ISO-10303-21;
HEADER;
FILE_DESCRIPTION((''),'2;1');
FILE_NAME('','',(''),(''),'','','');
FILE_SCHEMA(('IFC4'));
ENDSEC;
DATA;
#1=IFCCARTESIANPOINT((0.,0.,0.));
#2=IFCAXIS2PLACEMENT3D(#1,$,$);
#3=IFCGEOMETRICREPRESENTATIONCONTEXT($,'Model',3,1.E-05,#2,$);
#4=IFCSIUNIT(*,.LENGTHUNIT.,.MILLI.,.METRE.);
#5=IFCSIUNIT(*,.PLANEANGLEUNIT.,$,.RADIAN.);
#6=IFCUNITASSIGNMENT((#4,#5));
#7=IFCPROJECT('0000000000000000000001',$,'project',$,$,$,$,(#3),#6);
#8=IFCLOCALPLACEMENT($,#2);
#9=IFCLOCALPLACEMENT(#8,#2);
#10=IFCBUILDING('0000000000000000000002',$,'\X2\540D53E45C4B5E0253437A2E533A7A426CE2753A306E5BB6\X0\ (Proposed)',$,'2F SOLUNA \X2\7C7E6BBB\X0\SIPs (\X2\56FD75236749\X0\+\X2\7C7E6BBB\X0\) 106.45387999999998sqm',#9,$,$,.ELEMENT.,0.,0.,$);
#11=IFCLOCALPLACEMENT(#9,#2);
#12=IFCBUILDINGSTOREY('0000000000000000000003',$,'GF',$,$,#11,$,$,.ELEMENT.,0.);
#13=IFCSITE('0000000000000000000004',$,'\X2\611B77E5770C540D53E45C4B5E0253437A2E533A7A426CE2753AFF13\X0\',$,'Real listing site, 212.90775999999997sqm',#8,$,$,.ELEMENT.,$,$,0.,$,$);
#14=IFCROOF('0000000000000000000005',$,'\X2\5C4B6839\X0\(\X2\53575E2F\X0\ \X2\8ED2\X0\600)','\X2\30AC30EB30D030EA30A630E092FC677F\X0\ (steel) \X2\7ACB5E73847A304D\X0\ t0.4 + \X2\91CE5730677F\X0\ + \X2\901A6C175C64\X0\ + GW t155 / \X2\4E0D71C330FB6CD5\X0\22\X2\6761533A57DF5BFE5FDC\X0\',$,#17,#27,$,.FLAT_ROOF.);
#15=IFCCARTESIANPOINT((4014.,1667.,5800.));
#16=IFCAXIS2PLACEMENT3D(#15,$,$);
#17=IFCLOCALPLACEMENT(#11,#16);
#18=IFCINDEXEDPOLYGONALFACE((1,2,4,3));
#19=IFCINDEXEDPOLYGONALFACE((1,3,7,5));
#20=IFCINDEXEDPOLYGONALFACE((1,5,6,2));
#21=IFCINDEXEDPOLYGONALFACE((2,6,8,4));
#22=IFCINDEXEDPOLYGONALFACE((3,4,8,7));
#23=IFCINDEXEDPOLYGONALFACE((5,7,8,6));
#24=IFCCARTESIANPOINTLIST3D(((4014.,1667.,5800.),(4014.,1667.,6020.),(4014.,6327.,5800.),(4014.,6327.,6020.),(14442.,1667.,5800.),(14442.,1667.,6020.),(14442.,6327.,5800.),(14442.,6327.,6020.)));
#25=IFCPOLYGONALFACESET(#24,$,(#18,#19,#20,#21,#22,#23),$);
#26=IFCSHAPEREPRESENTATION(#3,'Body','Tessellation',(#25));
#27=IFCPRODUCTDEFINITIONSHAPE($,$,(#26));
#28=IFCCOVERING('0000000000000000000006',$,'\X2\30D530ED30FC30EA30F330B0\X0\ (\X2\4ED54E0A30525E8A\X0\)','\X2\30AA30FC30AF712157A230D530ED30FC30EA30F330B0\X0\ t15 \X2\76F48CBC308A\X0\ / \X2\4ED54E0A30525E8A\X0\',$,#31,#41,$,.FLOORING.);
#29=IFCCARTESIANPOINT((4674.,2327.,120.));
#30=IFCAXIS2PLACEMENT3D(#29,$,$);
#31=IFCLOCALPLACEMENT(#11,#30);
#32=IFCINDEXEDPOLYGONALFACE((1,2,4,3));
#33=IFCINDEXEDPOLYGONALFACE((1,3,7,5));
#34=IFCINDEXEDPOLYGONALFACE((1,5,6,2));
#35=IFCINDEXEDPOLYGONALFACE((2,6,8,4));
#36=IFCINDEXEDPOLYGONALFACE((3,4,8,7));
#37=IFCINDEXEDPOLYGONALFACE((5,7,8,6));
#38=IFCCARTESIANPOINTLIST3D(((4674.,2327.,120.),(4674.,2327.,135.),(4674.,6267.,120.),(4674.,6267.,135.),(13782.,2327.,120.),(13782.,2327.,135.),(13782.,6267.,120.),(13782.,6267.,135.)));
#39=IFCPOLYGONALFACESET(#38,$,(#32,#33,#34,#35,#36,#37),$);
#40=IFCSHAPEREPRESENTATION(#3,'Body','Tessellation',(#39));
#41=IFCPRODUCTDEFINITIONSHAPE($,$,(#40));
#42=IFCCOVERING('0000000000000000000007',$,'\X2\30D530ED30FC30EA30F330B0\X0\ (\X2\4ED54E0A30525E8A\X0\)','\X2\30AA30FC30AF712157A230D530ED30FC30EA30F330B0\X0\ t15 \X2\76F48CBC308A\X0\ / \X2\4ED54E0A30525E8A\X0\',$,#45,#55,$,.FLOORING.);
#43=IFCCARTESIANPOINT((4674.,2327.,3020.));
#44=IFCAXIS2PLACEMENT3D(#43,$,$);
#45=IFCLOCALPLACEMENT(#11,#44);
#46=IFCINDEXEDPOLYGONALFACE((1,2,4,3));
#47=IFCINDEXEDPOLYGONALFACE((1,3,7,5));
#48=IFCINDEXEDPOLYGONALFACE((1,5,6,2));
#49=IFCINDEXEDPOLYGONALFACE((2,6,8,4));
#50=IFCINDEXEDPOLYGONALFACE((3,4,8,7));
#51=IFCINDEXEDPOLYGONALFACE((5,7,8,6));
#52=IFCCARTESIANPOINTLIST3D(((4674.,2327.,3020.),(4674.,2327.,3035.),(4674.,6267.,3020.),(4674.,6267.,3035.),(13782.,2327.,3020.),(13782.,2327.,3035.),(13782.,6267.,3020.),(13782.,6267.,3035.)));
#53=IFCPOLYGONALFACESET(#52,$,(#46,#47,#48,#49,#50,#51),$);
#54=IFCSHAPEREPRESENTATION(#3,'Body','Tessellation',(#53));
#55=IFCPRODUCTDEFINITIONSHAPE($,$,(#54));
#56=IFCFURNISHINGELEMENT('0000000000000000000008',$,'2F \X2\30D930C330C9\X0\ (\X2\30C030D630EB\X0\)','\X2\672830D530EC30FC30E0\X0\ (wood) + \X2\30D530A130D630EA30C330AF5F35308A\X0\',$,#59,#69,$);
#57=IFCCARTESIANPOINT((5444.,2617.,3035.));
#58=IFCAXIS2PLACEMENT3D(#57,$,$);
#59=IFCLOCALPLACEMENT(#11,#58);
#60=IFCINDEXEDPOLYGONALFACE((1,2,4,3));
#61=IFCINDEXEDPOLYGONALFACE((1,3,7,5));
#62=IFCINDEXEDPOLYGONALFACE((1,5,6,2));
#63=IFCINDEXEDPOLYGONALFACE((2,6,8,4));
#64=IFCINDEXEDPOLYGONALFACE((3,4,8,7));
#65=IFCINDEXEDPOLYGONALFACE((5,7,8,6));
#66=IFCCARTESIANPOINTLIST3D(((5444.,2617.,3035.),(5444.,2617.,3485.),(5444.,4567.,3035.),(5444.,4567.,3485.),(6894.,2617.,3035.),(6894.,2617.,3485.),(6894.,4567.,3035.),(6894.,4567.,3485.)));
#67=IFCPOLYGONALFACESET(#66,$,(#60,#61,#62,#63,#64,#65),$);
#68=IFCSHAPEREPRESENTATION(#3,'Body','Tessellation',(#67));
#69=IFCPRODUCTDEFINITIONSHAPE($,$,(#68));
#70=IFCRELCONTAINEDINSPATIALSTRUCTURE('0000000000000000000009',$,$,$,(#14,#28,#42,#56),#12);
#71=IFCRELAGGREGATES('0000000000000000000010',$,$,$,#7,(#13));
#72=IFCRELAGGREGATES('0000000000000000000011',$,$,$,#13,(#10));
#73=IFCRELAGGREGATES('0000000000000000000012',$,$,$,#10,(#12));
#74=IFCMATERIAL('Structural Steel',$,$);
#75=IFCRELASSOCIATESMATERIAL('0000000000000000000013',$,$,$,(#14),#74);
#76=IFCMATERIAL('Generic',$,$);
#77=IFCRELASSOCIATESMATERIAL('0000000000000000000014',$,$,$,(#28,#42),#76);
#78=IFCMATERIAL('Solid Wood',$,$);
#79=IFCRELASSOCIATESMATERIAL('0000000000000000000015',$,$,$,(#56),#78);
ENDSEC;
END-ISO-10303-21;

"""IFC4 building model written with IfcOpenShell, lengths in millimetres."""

from ifc_helpers import new_model, si_unit, frame, frame_2d, origin, place, context, project, spatial, rectangle, extrude, material, element, save


model = new_model("IFC4")

# Units and contexts
model_context = context("Model", 3, precision=1e-05, world=origin())
ifc_project = project(units=[si_unit("LENGTHUNIT", "METRE", prefix="MILLI"), si_unit("PLANEANGLEUNIT", "RADIAN")], contexts=[model_context])

# Site, building, storey
site_placement = place(None, origin())
site = spatial("IfcSite", under=ifc_project, at=site_placement, Name="愛知県名古屋市千種区穂波町３", ObjectType="Real listing site, 212.90775999999997sqm", CompositionType="ELEMENT", RefElevation=0.0)
building_placement = place(site_placement, origin())
building = spatial("IfcBuilding", under=site, at=building_placement, Name="名古屋市千種区穂波町の家 (Proposed)", ObjectType="2F SOLUNA 籾殻SIPs (国産杉+籾殻) 106.45387999999998sqm", CompositionType="ELEMENT", ElevationOfRefHeight=0.0, ElevationOfTerrain=0.0)
storey_placement = place(building_placement, origin())
storey = spatial("IfcBuildingStorey", under=building, at=storey_placement, Name="GF", CompositionType="ELEMENT", Elevation=0.0)

# Shared definitions
ifc_material_1 = material(Name="Solid Wood")

# Roof
ifc_material_2 = material(Name="Structural Steel")
for number, where, name in (
    (1, (4014.0, 1667.0, 5800.0), "屋根(南帯 軒600)"),
):
    element("IfcRoof", number, at=place(storey_placement, frame(where)), inside=storey, material=ifc_material_2, Name=name, Description="ガルバリウム鋼板 (steel) 立平葺き t0.4 + 野地板 + 通気層 + GW t155 / 不燃・法22条区域対応", PredefinedType="FLAT_ROOF", context=model_context, shape_type="SweptSolid", body=[
        extrude(rectangle(XDim=10428.0, YDim=4660.0, at=frame_2d((5214.0, 2330.0))), frame((4014.0, 1667.0, 5800.0)), (0.0, 0.0, 1.0), 220.0),
    ])

# Coverings
ifc_material_3 = material(Name="Generic")
covering_1_placement = place(storey_placement, frame((4674.0, 2327.0, 120.0)))
element("IfcCovering", 2, at=covering_1_placement, inside=storey, material=ifc_material_3, Name="フローリング (仕上げ床)", Description="オーク無垢フローリング t15 直貼り / 仕上げ床", PredefinedType="FLOORING", context=model_context, shape_type="SweptSolid", body=[
    extrude(rectangle(XDim=9108.0, YDim=3940.0, at=frame_2d((4554.0, 1970.0))), frame((4674.0, 2327.0, 120.0)), (0.0, 0.0, 1.0), 15.0),
])
covering_2_placement = place(storey_placement, frame((4674.0, 2327.0, 3020.0)))
element("IfcCovering", 3, at=covering_2_placement, inside=storey, material=ifc_material_3, Name="フローリング (仕上げ床)", Description="オーク無垢フローリング t15 直貼り / 仕上げ床", PredefinedType="FLOORING", context=model_context, shape_type="SweptSolid", body=[
    extrude(rectangle(XDim=9108.0, YDim=3940.0, at=frame_2d((4554.0, 1970.0))), frame((4674.0, 2327.0, 3020.0)), (0.0, 0.0, 1.0), 15.0),
])

# Furnishing element
furnishing_placement = place(storey_placement, frame((5444.0, 2617.0, 3035.0)))
element("IfcFurnishingElement", 4, at=furnishing_placement, inside=storey, material=ifc_material_1, Name="2F ベッド (ダブル)", Description="木フレーム (wood) + ファブリック張り", context=model_context, shape_type="SweptSolid", body=[
    extrude(rectangle(XDim=1450.0, YDim=1950.0, at=frame_2d((725.0, 975.0))), frame((5444.0, 2617.0, 3035.0)), (0.0, 0.0, 1.0), 450.0),
])

save(model, "model.ifc")
